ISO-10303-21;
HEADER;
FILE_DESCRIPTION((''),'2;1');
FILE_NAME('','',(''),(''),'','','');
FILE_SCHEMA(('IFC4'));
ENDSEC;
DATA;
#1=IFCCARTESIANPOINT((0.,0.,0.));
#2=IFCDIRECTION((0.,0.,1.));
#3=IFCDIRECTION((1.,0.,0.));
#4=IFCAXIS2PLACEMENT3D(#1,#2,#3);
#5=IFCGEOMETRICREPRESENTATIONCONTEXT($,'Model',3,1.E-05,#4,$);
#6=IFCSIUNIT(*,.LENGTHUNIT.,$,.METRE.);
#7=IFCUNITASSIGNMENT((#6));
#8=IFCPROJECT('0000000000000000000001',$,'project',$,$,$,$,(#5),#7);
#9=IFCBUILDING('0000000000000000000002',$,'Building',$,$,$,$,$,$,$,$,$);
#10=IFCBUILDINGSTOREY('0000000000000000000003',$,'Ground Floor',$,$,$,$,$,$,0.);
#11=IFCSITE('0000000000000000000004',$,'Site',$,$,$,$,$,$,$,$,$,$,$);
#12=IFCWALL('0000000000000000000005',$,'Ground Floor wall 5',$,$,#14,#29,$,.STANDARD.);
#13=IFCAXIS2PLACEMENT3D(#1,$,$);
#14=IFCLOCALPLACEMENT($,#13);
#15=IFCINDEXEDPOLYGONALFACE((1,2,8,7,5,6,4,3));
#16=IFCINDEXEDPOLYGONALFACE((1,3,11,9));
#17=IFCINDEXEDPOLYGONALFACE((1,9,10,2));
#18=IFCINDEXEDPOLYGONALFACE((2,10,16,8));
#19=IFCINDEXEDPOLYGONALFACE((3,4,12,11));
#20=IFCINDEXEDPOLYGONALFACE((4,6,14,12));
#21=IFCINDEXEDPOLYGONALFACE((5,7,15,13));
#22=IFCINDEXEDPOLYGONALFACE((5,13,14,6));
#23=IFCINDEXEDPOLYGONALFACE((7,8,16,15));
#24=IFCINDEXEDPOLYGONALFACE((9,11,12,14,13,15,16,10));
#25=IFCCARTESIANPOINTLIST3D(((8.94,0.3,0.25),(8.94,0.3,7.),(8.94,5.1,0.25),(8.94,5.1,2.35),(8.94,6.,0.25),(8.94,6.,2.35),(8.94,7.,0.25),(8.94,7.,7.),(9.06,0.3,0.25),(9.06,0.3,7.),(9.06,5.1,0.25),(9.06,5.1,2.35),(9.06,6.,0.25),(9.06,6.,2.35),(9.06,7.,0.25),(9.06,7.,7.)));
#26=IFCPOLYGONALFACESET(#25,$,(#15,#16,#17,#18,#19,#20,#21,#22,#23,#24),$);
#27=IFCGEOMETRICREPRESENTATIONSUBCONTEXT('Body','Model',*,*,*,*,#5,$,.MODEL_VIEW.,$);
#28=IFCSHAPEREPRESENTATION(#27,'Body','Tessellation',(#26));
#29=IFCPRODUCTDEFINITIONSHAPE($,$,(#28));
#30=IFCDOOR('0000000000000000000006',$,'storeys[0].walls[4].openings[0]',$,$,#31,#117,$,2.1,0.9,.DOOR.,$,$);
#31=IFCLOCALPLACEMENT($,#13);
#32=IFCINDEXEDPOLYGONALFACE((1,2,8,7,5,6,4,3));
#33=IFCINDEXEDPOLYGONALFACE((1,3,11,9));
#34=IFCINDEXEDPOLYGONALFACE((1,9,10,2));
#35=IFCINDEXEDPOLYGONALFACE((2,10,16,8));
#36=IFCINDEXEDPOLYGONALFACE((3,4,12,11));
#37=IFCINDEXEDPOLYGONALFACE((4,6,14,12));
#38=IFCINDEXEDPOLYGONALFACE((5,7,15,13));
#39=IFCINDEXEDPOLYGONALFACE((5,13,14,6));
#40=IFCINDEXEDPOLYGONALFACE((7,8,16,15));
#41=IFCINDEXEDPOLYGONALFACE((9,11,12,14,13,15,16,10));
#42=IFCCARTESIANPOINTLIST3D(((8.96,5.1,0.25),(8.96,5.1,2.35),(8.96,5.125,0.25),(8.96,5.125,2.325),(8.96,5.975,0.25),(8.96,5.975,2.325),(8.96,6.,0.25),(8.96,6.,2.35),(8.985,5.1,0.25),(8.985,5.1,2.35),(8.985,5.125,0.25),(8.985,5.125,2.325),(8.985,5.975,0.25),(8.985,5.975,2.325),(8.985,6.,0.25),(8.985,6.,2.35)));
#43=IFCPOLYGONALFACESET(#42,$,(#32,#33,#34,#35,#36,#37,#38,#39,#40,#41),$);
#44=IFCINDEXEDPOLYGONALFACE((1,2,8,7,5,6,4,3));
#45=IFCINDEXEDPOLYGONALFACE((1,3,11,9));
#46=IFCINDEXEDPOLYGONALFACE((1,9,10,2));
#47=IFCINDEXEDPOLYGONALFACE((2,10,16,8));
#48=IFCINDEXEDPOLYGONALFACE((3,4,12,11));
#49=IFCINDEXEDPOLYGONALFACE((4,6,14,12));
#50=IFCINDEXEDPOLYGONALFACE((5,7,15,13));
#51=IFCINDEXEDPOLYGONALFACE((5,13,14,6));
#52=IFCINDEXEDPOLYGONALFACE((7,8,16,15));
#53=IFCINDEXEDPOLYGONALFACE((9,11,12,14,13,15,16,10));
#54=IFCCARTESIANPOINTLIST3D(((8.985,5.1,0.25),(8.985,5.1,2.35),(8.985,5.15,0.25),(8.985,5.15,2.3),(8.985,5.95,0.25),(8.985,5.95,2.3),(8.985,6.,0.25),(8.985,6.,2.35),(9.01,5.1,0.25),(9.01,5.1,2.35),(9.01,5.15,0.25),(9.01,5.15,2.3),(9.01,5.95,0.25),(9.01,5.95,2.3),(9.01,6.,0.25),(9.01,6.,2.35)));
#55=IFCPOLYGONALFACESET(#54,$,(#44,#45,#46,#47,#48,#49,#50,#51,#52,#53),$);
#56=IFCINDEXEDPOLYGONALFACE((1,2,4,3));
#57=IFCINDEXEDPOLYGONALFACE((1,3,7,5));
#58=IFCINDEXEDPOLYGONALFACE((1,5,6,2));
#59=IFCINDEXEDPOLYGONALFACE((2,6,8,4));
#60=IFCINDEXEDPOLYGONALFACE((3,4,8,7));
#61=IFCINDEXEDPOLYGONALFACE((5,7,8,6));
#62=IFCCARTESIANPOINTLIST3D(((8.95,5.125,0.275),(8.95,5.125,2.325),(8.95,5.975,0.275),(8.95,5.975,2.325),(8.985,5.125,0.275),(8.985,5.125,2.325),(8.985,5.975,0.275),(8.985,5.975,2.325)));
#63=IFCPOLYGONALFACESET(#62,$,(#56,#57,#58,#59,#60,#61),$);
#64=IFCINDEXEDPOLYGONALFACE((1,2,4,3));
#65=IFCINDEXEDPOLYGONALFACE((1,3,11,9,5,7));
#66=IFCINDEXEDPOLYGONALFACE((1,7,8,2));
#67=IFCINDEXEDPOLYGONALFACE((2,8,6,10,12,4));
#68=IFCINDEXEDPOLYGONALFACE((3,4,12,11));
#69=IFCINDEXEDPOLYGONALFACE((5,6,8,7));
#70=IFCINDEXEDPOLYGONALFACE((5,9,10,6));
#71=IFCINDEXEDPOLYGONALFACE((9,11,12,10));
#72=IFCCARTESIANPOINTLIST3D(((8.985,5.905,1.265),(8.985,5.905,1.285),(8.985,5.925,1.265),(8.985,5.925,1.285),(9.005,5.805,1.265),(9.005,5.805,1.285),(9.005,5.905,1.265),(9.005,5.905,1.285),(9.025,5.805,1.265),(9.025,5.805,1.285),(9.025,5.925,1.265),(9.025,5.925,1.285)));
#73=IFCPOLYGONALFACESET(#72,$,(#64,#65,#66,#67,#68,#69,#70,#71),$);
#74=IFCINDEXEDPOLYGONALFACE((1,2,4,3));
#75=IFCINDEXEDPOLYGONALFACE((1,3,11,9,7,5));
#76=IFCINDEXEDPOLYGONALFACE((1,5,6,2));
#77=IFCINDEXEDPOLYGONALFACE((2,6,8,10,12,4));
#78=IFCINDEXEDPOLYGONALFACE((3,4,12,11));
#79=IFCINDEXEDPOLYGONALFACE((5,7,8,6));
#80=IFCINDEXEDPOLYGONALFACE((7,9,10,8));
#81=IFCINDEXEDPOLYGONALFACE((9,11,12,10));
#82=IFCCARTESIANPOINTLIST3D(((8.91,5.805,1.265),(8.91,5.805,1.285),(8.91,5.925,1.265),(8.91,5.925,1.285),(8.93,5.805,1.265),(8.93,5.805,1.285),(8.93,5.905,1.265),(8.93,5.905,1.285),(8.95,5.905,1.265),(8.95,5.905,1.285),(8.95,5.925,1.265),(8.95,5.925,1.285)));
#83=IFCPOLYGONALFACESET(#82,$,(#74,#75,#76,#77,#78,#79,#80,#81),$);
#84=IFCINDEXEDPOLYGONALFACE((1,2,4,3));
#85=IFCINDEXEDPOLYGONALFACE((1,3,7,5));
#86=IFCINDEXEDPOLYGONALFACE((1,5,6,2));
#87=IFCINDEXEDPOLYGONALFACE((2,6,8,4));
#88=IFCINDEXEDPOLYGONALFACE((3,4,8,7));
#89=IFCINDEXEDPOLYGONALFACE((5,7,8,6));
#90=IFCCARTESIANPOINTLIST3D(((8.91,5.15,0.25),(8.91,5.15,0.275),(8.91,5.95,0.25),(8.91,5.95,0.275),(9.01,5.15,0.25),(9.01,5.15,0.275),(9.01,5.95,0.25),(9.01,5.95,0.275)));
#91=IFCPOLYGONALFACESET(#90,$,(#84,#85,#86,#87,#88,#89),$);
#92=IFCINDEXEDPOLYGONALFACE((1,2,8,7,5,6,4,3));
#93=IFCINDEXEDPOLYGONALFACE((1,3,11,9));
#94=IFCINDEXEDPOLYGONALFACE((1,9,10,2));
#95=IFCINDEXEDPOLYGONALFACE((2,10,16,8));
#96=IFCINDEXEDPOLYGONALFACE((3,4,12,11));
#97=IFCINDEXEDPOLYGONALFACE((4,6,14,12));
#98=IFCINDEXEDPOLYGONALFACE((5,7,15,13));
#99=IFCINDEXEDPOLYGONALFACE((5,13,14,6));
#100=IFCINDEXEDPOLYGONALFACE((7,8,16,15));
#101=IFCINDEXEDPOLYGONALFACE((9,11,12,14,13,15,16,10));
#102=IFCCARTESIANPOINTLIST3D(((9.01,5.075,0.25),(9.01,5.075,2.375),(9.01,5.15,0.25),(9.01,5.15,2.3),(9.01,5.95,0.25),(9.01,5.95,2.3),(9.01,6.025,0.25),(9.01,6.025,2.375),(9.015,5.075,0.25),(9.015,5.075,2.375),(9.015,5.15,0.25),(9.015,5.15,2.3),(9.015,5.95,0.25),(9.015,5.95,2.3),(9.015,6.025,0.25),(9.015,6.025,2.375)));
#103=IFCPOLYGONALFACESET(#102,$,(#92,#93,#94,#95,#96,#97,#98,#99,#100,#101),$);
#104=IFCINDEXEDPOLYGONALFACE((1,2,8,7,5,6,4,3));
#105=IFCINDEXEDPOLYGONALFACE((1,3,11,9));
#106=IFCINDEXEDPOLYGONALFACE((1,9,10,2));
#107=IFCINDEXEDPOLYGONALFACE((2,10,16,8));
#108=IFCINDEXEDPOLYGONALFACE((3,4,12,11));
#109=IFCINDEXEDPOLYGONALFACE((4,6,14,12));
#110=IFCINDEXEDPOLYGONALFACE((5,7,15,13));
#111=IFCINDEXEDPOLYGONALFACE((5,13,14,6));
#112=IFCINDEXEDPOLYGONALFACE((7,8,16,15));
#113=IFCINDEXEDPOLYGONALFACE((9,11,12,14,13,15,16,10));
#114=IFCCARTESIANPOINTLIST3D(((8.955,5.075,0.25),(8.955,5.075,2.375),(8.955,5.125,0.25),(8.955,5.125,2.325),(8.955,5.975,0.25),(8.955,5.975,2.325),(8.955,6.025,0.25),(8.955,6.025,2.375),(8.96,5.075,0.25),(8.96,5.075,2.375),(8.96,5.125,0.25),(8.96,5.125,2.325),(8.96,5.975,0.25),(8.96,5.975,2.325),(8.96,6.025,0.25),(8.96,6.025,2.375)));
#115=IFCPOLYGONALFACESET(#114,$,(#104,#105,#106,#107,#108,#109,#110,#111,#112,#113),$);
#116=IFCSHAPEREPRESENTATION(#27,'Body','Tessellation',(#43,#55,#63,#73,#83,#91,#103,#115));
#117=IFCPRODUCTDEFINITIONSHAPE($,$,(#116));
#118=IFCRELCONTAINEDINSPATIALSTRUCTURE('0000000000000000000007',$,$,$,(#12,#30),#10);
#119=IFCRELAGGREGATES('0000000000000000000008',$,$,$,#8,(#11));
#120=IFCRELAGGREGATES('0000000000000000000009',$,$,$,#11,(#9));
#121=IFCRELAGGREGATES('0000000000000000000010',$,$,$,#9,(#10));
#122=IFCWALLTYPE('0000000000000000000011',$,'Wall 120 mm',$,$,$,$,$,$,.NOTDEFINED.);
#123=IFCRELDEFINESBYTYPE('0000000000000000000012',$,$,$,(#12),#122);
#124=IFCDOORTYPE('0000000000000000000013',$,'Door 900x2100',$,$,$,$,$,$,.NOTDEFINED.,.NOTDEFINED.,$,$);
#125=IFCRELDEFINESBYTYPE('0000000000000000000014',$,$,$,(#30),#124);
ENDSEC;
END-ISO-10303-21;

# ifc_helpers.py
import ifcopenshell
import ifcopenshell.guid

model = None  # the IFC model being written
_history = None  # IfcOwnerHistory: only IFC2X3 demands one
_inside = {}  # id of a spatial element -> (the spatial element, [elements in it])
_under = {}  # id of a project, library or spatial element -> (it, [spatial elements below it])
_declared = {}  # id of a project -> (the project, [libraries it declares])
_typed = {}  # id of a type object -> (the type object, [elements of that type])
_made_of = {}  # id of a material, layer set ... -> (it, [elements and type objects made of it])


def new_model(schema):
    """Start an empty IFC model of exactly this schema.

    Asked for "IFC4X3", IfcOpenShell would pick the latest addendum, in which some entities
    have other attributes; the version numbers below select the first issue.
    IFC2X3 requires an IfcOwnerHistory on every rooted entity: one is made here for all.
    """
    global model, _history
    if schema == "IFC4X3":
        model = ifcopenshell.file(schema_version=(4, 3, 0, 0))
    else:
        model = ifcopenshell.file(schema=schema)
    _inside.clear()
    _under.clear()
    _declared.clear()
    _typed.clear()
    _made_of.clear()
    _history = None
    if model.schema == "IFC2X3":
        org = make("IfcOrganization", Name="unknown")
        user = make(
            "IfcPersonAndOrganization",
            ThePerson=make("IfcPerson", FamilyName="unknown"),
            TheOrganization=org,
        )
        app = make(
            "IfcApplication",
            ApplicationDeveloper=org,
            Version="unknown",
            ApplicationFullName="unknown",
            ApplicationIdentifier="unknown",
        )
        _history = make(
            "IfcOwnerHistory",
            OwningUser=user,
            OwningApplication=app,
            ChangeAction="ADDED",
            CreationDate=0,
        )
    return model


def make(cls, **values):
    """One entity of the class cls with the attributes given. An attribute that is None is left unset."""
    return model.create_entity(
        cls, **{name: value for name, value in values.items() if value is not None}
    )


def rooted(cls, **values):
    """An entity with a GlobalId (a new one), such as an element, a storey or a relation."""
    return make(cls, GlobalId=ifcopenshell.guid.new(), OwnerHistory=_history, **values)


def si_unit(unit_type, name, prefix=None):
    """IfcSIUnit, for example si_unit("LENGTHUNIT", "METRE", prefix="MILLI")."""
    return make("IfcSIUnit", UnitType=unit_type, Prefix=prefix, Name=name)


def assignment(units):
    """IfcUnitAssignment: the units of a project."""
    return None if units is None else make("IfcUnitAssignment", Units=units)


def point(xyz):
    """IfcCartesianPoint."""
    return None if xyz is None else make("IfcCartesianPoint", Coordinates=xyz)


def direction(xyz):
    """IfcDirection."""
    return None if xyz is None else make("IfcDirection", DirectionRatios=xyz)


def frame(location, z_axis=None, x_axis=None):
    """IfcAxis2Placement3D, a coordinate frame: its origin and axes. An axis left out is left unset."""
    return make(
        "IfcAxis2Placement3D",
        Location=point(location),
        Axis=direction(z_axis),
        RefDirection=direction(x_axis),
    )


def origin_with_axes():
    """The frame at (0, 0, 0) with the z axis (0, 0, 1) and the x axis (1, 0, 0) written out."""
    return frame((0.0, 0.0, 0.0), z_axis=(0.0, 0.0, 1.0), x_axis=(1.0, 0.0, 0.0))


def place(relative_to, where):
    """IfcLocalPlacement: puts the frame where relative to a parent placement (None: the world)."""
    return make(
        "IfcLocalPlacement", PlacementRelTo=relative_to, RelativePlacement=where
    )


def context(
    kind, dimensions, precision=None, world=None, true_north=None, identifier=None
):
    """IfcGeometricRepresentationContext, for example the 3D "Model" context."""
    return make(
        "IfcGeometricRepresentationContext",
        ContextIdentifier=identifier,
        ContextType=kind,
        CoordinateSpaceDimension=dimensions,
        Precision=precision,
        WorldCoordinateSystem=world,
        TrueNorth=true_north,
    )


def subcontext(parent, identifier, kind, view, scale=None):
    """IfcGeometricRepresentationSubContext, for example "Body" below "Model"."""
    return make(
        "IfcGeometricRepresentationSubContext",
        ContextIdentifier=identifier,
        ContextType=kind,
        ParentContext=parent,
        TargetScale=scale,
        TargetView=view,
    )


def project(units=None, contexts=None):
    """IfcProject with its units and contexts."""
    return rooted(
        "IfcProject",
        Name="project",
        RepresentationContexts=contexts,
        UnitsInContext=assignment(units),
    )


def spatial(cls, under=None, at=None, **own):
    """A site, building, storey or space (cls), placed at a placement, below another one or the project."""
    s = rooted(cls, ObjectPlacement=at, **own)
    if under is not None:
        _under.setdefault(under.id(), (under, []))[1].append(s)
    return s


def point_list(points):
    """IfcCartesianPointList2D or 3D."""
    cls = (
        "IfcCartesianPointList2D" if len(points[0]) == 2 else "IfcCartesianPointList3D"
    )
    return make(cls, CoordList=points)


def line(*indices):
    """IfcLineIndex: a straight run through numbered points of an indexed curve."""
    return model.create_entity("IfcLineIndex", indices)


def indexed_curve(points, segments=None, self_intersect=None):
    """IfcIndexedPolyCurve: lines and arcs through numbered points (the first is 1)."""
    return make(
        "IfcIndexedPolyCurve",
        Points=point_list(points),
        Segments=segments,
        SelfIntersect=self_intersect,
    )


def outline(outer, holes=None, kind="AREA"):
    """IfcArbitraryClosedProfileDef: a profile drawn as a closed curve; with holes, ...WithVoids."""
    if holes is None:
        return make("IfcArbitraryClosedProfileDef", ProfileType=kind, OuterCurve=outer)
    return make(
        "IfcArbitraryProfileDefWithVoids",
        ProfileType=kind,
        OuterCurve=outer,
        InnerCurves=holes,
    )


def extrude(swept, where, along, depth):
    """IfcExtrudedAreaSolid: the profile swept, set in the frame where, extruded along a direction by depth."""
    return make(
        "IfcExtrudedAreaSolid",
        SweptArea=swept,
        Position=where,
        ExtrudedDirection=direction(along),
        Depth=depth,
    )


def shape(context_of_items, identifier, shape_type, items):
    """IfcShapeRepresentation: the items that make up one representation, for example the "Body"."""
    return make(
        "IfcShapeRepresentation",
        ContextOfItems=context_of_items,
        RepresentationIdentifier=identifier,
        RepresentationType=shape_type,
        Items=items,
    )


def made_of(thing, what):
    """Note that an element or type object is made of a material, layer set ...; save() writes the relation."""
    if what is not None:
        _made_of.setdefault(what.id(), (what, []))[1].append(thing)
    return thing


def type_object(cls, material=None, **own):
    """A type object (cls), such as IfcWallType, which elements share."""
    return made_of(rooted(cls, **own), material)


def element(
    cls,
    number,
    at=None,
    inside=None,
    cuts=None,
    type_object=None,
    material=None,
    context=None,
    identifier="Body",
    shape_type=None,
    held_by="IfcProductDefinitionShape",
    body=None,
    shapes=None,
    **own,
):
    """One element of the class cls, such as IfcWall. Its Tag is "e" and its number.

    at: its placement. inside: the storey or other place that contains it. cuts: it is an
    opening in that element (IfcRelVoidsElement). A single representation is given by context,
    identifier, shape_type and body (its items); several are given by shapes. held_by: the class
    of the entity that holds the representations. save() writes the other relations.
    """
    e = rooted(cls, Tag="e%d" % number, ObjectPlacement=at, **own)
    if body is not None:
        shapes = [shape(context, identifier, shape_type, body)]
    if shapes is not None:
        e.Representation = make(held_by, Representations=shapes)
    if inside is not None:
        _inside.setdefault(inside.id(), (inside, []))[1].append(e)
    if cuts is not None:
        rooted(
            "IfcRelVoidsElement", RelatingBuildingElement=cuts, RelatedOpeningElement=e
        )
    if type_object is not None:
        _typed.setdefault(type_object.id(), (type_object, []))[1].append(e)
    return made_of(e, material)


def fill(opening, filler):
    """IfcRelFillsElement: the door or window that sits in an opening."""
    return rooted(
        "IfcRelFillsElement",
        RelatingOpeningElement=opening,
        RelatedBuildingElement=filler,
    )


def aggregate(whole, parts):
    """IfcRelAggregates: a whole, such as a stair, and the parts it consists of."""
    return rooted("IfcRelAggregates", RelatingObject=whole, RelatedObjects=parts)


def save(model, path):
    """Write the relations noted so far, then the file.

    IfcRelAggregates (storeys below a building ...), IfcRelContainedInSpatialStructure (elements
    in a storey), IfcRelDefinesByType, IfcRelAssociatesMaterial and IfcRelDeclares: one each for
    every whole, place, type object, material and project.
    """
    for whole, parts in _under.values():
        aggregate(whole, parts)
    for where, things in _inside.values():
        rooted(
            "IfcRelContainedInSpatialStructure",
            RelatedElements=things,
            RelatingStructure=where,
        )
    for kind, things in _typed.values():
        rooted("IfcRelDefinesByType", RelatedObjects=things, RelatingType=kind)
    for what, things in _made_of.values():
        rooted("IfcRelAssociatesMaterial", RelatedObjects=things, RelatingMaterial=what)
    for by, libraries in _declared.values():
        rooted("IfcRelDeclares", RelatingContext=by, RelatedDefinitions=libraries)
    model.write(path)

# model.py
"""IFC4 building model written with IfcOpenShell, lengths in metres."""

from ifc_helpers import new_model, si_unit, frame, origin_with_axes, place, context, subcontext, project, spatial, line, indexed_curve, outline, extrude, type_object, element, fill, save


model = new_model("IFC4")

# Units and contexts
model_context = context("Model", 3, precision=1e-05, world=origin_with_axes())
body_context = subcontext(model_context, "Body", "Model", "MODEL_VIEW")
ifc_project = project(units=[si_unit("LENGTHUNIT", "METRE")], contexts=[model_context])

# Site, building, storey
site = spatial("IfcSite", under=ifc_project, Name="Site")
building = spatial("IfcBuilding", under=site, Name="Building")
storey = spatial("IfcBuildingStorey", under=building, Name="Ground Floor", Elevation=0.0)

# Wall, opening, door
wall_type_1 = type_object("IfcWallType", Name="Wall 120 mm", PredefinedType="NOTDEFINED")
wall_1_placement = place(None, frame((9.0, 0.3, 0.25), z_axis=(0.0, 0.0, 1.0), x_axis=(0.0, 1.0, 0.0)))
wall_1 = element("IfcWall", 1, at=wall_1_placement, inside=storey, type_object=wall_type_1, Name="Ground Floor wall 5", PredefinedType="STANDARD", context=body_context, shape_type="SweptSolid", body=[
    extrude(outline(indexed_curve([(0.0, 0.0), (0.0, 0.12), (6.7, 0.12), (6.7, 0.0), (0.0, 0.0)], self_intersect=False)), frame((0.0, -0.06, 0.0), z_axis=(0.0, 0.0, 1.0), x_axis=(1.0, 0.0, 0.0)), (0.0, 0.0, 1.0), 6.75),
])
opening_1_placement = place(wall_1_placement, frame((4.8, -0.07, 0.0), z_axis=(0.0, 0.0, 1.0), x_axis=(1.0, 0.0, 0.0)))
opening_1 = element("IfcOpeningElement", 2, at=opening_1_placement, cuts=wall_1, context=body_context, shape_type="SweptSolid", body=[
    extrude(outline(indexed_curve([(0.0, 0.0), (0.0, 0.14), (0.9, 0.14), (0.9, 0.0), (0.0, 0.0)], self_intersect=False)), origin_with_axes(), (0.0, 0.0, 1.0), 2.1),
])
door_type_1 = type_object("IfcDoorType", Name="Door 900x2100", OperationType="NOTDEFINED", PredefinedType="NOTDEFINED")
door_1_placement = place(None, frame((9.01, 5.1, 0.25), z_axis=(0.0, 0.0, 1.0), x_axis=(0.0, 1.0, 0.0)))
door_1 = element("IfcDoor", 3, at=door_1_placement, inside=storey, type_object=door_type_1, Name="storeys[0].walls[4].openings[0]", OverallHeight=2.1, OverallWidth=0.9, PredefinedType="DOOR", context=body_context, shape_type="SweptSolid", body=[
    extrude(outline(indexed_curve([(0.0, 0.0), (0.0, 2.1), (0.9, 2.1), (0.9, 0.0), (0.875, 0.0), (0.875, 2.075), (0.025, 2.075), (0.025, 0.0)], segments=[line(1, 2, 3, 4, 5, 6, 7, 8, 1)])), frame((0.0, 0.025, 0.0), z_axis=(0.0, -1.0, 0.0), x_axis=(1.0, 0.0, 0.0)), (0.0, 0.0, -1.0), 0.025),
    extrude(outline(indexed_curve([(0.0, 0.0), (0.0, 2.1), (0.9, 2.1), (0.9, 0.0), (0.85, 0.0), (0.85, 2.05), (0.05, 2.05), (0.05, 0.0)], segments=[line(1, 2, 3, 4, 5, 6, 7, 8, 1)])), frame((0.0, 0.0, 0.0), z_axis=(0.0, -1.0, 0.0), x_axis=(1.0, 0.0, 0.0)), (0.0, 0.0, -1.0), 0.025),
    extrude(outline(indexed_curve([(0.0, 0.0), (0.85, 0.0), (0.85, 0.035), (0.0, 0.035)], segments=[line(1, 2, 3, 4, 1)])), frame((0.025, 0.025, 0.025), z_axis=(0.0, 0.0, 1.0), x_axis=(1.0, 0.0, 0.0)), (0.0, 0.0, 1.0), 2.05),
    extrude(outline(indexed_curve([(0.0, 0.0), (0.0, -0.04), (-0.12, -0.04), (-0.12, -0.02), (-0.02, -0.02), (-0.02, 0.0)], segments=[line(1, 2, 3, 4, 5, 6, 1)])), frame((0.825, 0.025, 1.015), z_axis=(0.0, 0.0, 1.0), x_axis=(1.0, 0.0, 0.0)), (0.0, 0.0, 1.0), 0.02),
    extrude(outline(indexed_curve([(0.0, 0.0), (0.0, 0.04), (-0.12, 0.04), (-0.12, 0.02), (-0.02, 0.02), (-0.02, 0.0)], segments=[line(1, 2, 3, 4, 5, 6, 1)])), frame((0.825, 0.06, 1.015), z_axis=(0.0, 0.0, 1.0), x_axis=(1.0, 0.0, 0.0)), (0.0, 0.0, 1.0), 0.02),
    extrude(outline(indexed_curve([(0.0, 0.0), (0.8, 0.0), (0.8, 0.1), (0.0, 0.1)], segments=[line(1, 2, 3, 4, 1)])), frame((0.05, 0.0, 0.0), z_axis=(0.0, 0.0, 1.0), x_axis=(1.0, 0.0, 0.0)), (0.0, 0.0, 1.0), 0.025),
    extrude(outline(indexed_curve([(0.0, 0.0), (0.0, 2.125), (0.95, 2.125), (0.95, 0.0), (0.875, 0.0), (0.875, 2.05), (0.075, 2.05), (0.075, 0.0)], segments=[line(1, 2, 3, 4, 5, 6, 7, 8, 1)])), frame((-0.025, -0.005, 0.0), z_axis=(0.0, -1.0, 0.0), x_axis=(1.0, 0.0, 0.0)), (0.0, 0.0, -1.0), 0.005),
    extrude(outline(indexed_curve([(0.0, 0.0), (0.0, 2.125), (0.95, 2.125), (0.95, 0.0), (0.9, 0.0), (0.9, 2.075), (0.05, 2.075), (0.05, 0.0)], segments=[line(1, 2, 3, 4, 5, 6, 7, 8, 1)])), frame((-0.025, 0.05, 0.0), z_axis=(0.0, -1.0, 0.0), x_axis=(1.0, 0.0, 0.0)), (0.0, 0.0, -1.0), 0.005),
])
fill(opening_1, door_1)

save(model, "model.ifc")
